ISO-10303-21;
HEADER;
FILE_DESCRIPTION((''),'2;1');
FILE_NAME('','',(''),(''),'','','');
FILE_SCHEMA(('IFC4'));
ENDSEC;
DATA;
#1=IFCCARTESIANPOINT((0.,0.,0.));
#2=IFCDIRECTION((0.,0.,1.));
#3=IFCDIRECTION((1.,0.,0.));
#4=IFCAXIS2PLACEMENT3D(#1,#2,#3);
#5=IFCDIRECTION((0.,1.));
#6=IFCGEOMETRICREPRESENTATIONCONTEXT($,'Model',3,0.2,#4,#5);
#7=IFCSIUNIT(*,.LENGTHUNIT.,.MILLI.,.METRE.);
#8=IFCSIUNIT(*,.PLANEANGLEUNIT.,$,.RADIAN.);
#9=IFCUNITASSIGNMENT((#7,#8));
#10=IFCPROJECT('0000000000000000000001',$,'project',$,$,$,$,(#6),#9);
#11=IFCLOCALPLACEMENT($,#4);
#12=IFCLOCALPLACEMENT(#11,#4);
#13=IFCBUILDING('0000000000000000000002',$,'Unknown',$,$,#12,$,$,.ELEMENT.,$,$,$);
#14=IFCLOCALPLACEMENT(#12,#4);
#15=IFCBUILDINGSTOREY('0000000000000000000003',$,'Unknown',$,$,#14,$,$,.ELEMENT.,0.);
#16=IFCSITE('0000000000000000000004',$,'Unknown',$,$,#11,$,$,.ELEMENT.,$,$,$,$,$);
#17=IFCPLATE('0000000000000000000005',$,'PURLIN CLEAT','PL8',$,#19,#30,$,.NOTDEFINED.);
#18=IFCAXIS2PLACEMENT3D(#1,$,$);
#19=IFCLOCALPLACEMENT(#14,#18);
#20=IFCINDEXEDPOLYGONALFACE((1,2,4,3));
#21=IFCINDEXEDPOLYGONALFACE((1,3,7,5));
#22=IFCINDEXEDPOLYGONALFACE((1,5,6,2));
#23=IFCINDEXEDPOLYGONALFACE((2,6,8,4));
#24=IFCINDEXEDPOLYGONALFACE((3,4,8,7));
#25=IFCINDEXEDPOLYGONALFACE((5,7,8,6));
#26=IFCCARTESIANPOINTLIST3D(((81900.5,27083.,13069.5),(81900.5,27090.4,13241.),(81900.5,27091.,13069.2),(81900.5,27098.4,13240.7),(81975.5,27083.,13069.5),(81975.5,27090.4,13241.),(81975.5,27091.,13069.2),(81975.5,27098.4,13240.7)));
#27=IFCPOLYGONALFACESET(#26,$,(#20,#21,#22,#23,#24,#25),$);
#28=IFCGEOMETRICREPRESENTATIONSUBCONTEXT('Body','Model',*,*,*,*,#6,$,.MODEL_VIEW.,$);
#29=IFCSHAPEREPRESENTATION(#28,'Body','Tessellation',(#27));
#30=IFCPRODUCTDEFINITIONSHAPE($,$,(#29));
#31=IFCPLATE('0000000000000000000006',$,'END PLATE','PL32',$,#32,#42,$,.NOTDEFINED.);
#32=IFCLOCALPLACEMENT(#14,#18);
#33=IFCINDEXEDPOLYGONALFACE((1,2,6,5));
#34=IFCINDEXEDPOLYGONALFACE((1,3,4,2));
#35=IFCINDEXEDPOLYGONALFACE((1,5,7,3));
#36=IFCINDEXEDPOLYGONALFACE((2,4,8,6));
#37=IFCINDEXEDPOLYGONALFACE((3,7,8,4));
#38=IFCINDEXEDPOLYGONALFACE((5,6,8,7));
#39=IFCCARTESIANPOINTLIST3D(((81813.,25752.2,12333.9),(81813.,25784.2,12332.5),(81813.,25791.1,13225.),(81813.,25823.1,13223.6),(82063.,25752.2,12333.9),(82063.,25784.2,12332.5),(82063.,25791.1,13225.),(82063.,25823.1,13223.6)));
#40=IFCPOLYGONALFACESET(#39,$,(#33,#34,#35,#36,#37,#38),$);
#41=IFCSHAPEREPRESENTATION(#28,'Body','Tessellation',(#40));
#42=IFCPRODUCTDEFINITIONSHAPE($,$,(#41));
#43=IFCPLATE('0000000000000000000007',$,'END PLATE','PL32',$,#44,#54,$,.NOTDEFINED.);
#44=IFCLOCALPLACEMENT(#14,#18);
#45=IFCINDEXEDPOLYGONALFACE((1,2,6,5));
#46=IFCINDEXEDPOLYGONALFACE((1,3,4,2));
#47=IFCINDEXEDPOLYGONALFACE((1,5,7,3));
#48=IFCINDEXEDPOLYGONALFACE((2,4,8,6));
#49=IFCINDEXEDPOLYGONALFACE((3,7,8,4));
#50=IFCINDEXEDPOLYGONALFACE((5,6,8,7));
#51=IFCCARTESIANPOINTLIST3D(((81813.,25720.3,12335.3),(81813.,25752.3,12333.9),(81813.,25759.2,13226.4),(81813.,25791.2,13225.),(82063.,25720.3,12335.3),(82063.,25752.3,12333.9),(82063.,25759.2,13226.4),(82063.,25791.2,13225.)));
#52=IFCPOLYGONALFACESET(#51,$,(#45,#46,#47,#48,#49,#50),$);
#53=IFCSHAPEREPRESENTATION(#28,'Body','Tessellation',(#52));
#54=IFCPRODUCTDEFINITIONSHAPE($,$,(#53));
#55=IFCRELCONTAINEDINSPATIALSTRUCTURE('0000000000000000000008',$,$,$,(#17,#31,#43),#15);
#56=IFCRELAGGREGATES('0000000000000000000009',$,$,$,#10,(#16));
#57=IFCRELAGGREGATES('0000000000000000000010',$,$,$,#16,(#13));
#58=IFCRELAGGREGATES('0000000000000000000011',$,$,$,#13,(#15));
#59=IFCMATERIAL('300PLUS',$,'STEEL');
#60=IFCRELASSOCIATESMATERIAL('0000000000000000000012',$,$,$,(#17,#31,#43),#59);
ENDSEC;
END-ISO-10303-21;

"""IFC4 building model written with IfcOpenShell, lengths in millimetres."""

from ifc_helpers import new_model, si_unit, direction, frame, origin_with_axes, place, context, subcontext, project, spatial, line, indexed_curve, outline, extrude, material, element, save


model = new_model("IFC4")

# Units and contexts
model_context = context("Model", 3, precision=0.2, world=origin_with_axes(), true_north=direction((0.0, 1.0)))
body_context = subcontext(model_context, "Body", "Model", "MODEL_VIEW")
ifc_project = project(units=[si_unit("LENGTHUNIT", "METRE", prefix="MILLI"), si_unit("PLANEANGLEUNIT", "RADIAN")], contexts=[model_context])

# Site, building, storey
site_placement = place(None, origin_with_axes())
site = spatial("IfcSite", under=ifc_project, at=site_placement, Name="Unknown", CompositionType="ELEMENT")
building_placement = place(site_placement, origin_with_axes())
building = spatial("IfcBuilding", under=site, at=building_placement, Name="Unknown", CompositionType="ELEMENT")
storey_placement = place(building_placement, origin_with_axes())
storey = spatial("IfcBuildingStorey", under=building, at=storey_placement, Name="Unknown", CompositionType="ELEMENT", Elevation=0.0)

# Plates
ifc_material_1 = material(Name="300PLUS", Category="STEEL")
plate_1_placement = place(storey_placement, frame((81900.5, 27087.0, 13069.4), z_axis=(0.0, -0.99907, 0.043109), x_axis=(1.0, 0.0, 0.0)))
element("IfcPlate", 1, at=plate_1_placement, inside=storey, material=ifc_material_1, Name="PURLIN CLEAT", Description="PL8", PredefinedType="NOTDEFINED", context=body_context, shape_type="SolidModel", body=[
    extrude(outline(indexed_curve([(0.0, 0.0), (75.0, 0.0), (75.0, 171.7), (0.0, 171.7)], segments=[line(1, 2, 3, 4, 1)])), frame((0.0, 0.0, 4.0), z_axis=(0.0, 0.0, 1.0), x_axis=(1.0, 0.0, 0.0)), (0.0, 0.0, -1.0), 8.0),
])
for number, where, z_axis, x_axis, name in (
    (2, (82063.0, 25807.1, 13224.3), (0.0, -0.999049, 0.043612), (-1.0, 0.0, 0.0), "END PLATE"),
    (3, (82063.0, 25775.2, 13225.7), (0.0, -0.999049, 0.043612), (-1.0, 0.0, 0.0), "END PLATE"),
):
    element("IfcPlate", number, at=place(storey_placement, frame(where, z_axis=z_axis, x_axis=x_axis)), inside=storey, material=ifc_material_1, Name=name, Description="PL32", PredefinedType="NOTDEFINED", context=body_context, shape_type="SolidModel", body=[
        extrude(outline(indexed_curve([(0.0, 0.0), (250.0, 0.0), (250.0, 891.9), (0.0, 891.9)], segments=[line(1, 2, 3, 4, 1)])), frame((0.0, 0.0, 16.0), z_axis=(0.0, 0.0, 1.0), x_axis=(1.0, 0.0, 0.0)), (0.0, 0.0, -1.0), 32.0),
    ])

save(model, "model.ifc")
